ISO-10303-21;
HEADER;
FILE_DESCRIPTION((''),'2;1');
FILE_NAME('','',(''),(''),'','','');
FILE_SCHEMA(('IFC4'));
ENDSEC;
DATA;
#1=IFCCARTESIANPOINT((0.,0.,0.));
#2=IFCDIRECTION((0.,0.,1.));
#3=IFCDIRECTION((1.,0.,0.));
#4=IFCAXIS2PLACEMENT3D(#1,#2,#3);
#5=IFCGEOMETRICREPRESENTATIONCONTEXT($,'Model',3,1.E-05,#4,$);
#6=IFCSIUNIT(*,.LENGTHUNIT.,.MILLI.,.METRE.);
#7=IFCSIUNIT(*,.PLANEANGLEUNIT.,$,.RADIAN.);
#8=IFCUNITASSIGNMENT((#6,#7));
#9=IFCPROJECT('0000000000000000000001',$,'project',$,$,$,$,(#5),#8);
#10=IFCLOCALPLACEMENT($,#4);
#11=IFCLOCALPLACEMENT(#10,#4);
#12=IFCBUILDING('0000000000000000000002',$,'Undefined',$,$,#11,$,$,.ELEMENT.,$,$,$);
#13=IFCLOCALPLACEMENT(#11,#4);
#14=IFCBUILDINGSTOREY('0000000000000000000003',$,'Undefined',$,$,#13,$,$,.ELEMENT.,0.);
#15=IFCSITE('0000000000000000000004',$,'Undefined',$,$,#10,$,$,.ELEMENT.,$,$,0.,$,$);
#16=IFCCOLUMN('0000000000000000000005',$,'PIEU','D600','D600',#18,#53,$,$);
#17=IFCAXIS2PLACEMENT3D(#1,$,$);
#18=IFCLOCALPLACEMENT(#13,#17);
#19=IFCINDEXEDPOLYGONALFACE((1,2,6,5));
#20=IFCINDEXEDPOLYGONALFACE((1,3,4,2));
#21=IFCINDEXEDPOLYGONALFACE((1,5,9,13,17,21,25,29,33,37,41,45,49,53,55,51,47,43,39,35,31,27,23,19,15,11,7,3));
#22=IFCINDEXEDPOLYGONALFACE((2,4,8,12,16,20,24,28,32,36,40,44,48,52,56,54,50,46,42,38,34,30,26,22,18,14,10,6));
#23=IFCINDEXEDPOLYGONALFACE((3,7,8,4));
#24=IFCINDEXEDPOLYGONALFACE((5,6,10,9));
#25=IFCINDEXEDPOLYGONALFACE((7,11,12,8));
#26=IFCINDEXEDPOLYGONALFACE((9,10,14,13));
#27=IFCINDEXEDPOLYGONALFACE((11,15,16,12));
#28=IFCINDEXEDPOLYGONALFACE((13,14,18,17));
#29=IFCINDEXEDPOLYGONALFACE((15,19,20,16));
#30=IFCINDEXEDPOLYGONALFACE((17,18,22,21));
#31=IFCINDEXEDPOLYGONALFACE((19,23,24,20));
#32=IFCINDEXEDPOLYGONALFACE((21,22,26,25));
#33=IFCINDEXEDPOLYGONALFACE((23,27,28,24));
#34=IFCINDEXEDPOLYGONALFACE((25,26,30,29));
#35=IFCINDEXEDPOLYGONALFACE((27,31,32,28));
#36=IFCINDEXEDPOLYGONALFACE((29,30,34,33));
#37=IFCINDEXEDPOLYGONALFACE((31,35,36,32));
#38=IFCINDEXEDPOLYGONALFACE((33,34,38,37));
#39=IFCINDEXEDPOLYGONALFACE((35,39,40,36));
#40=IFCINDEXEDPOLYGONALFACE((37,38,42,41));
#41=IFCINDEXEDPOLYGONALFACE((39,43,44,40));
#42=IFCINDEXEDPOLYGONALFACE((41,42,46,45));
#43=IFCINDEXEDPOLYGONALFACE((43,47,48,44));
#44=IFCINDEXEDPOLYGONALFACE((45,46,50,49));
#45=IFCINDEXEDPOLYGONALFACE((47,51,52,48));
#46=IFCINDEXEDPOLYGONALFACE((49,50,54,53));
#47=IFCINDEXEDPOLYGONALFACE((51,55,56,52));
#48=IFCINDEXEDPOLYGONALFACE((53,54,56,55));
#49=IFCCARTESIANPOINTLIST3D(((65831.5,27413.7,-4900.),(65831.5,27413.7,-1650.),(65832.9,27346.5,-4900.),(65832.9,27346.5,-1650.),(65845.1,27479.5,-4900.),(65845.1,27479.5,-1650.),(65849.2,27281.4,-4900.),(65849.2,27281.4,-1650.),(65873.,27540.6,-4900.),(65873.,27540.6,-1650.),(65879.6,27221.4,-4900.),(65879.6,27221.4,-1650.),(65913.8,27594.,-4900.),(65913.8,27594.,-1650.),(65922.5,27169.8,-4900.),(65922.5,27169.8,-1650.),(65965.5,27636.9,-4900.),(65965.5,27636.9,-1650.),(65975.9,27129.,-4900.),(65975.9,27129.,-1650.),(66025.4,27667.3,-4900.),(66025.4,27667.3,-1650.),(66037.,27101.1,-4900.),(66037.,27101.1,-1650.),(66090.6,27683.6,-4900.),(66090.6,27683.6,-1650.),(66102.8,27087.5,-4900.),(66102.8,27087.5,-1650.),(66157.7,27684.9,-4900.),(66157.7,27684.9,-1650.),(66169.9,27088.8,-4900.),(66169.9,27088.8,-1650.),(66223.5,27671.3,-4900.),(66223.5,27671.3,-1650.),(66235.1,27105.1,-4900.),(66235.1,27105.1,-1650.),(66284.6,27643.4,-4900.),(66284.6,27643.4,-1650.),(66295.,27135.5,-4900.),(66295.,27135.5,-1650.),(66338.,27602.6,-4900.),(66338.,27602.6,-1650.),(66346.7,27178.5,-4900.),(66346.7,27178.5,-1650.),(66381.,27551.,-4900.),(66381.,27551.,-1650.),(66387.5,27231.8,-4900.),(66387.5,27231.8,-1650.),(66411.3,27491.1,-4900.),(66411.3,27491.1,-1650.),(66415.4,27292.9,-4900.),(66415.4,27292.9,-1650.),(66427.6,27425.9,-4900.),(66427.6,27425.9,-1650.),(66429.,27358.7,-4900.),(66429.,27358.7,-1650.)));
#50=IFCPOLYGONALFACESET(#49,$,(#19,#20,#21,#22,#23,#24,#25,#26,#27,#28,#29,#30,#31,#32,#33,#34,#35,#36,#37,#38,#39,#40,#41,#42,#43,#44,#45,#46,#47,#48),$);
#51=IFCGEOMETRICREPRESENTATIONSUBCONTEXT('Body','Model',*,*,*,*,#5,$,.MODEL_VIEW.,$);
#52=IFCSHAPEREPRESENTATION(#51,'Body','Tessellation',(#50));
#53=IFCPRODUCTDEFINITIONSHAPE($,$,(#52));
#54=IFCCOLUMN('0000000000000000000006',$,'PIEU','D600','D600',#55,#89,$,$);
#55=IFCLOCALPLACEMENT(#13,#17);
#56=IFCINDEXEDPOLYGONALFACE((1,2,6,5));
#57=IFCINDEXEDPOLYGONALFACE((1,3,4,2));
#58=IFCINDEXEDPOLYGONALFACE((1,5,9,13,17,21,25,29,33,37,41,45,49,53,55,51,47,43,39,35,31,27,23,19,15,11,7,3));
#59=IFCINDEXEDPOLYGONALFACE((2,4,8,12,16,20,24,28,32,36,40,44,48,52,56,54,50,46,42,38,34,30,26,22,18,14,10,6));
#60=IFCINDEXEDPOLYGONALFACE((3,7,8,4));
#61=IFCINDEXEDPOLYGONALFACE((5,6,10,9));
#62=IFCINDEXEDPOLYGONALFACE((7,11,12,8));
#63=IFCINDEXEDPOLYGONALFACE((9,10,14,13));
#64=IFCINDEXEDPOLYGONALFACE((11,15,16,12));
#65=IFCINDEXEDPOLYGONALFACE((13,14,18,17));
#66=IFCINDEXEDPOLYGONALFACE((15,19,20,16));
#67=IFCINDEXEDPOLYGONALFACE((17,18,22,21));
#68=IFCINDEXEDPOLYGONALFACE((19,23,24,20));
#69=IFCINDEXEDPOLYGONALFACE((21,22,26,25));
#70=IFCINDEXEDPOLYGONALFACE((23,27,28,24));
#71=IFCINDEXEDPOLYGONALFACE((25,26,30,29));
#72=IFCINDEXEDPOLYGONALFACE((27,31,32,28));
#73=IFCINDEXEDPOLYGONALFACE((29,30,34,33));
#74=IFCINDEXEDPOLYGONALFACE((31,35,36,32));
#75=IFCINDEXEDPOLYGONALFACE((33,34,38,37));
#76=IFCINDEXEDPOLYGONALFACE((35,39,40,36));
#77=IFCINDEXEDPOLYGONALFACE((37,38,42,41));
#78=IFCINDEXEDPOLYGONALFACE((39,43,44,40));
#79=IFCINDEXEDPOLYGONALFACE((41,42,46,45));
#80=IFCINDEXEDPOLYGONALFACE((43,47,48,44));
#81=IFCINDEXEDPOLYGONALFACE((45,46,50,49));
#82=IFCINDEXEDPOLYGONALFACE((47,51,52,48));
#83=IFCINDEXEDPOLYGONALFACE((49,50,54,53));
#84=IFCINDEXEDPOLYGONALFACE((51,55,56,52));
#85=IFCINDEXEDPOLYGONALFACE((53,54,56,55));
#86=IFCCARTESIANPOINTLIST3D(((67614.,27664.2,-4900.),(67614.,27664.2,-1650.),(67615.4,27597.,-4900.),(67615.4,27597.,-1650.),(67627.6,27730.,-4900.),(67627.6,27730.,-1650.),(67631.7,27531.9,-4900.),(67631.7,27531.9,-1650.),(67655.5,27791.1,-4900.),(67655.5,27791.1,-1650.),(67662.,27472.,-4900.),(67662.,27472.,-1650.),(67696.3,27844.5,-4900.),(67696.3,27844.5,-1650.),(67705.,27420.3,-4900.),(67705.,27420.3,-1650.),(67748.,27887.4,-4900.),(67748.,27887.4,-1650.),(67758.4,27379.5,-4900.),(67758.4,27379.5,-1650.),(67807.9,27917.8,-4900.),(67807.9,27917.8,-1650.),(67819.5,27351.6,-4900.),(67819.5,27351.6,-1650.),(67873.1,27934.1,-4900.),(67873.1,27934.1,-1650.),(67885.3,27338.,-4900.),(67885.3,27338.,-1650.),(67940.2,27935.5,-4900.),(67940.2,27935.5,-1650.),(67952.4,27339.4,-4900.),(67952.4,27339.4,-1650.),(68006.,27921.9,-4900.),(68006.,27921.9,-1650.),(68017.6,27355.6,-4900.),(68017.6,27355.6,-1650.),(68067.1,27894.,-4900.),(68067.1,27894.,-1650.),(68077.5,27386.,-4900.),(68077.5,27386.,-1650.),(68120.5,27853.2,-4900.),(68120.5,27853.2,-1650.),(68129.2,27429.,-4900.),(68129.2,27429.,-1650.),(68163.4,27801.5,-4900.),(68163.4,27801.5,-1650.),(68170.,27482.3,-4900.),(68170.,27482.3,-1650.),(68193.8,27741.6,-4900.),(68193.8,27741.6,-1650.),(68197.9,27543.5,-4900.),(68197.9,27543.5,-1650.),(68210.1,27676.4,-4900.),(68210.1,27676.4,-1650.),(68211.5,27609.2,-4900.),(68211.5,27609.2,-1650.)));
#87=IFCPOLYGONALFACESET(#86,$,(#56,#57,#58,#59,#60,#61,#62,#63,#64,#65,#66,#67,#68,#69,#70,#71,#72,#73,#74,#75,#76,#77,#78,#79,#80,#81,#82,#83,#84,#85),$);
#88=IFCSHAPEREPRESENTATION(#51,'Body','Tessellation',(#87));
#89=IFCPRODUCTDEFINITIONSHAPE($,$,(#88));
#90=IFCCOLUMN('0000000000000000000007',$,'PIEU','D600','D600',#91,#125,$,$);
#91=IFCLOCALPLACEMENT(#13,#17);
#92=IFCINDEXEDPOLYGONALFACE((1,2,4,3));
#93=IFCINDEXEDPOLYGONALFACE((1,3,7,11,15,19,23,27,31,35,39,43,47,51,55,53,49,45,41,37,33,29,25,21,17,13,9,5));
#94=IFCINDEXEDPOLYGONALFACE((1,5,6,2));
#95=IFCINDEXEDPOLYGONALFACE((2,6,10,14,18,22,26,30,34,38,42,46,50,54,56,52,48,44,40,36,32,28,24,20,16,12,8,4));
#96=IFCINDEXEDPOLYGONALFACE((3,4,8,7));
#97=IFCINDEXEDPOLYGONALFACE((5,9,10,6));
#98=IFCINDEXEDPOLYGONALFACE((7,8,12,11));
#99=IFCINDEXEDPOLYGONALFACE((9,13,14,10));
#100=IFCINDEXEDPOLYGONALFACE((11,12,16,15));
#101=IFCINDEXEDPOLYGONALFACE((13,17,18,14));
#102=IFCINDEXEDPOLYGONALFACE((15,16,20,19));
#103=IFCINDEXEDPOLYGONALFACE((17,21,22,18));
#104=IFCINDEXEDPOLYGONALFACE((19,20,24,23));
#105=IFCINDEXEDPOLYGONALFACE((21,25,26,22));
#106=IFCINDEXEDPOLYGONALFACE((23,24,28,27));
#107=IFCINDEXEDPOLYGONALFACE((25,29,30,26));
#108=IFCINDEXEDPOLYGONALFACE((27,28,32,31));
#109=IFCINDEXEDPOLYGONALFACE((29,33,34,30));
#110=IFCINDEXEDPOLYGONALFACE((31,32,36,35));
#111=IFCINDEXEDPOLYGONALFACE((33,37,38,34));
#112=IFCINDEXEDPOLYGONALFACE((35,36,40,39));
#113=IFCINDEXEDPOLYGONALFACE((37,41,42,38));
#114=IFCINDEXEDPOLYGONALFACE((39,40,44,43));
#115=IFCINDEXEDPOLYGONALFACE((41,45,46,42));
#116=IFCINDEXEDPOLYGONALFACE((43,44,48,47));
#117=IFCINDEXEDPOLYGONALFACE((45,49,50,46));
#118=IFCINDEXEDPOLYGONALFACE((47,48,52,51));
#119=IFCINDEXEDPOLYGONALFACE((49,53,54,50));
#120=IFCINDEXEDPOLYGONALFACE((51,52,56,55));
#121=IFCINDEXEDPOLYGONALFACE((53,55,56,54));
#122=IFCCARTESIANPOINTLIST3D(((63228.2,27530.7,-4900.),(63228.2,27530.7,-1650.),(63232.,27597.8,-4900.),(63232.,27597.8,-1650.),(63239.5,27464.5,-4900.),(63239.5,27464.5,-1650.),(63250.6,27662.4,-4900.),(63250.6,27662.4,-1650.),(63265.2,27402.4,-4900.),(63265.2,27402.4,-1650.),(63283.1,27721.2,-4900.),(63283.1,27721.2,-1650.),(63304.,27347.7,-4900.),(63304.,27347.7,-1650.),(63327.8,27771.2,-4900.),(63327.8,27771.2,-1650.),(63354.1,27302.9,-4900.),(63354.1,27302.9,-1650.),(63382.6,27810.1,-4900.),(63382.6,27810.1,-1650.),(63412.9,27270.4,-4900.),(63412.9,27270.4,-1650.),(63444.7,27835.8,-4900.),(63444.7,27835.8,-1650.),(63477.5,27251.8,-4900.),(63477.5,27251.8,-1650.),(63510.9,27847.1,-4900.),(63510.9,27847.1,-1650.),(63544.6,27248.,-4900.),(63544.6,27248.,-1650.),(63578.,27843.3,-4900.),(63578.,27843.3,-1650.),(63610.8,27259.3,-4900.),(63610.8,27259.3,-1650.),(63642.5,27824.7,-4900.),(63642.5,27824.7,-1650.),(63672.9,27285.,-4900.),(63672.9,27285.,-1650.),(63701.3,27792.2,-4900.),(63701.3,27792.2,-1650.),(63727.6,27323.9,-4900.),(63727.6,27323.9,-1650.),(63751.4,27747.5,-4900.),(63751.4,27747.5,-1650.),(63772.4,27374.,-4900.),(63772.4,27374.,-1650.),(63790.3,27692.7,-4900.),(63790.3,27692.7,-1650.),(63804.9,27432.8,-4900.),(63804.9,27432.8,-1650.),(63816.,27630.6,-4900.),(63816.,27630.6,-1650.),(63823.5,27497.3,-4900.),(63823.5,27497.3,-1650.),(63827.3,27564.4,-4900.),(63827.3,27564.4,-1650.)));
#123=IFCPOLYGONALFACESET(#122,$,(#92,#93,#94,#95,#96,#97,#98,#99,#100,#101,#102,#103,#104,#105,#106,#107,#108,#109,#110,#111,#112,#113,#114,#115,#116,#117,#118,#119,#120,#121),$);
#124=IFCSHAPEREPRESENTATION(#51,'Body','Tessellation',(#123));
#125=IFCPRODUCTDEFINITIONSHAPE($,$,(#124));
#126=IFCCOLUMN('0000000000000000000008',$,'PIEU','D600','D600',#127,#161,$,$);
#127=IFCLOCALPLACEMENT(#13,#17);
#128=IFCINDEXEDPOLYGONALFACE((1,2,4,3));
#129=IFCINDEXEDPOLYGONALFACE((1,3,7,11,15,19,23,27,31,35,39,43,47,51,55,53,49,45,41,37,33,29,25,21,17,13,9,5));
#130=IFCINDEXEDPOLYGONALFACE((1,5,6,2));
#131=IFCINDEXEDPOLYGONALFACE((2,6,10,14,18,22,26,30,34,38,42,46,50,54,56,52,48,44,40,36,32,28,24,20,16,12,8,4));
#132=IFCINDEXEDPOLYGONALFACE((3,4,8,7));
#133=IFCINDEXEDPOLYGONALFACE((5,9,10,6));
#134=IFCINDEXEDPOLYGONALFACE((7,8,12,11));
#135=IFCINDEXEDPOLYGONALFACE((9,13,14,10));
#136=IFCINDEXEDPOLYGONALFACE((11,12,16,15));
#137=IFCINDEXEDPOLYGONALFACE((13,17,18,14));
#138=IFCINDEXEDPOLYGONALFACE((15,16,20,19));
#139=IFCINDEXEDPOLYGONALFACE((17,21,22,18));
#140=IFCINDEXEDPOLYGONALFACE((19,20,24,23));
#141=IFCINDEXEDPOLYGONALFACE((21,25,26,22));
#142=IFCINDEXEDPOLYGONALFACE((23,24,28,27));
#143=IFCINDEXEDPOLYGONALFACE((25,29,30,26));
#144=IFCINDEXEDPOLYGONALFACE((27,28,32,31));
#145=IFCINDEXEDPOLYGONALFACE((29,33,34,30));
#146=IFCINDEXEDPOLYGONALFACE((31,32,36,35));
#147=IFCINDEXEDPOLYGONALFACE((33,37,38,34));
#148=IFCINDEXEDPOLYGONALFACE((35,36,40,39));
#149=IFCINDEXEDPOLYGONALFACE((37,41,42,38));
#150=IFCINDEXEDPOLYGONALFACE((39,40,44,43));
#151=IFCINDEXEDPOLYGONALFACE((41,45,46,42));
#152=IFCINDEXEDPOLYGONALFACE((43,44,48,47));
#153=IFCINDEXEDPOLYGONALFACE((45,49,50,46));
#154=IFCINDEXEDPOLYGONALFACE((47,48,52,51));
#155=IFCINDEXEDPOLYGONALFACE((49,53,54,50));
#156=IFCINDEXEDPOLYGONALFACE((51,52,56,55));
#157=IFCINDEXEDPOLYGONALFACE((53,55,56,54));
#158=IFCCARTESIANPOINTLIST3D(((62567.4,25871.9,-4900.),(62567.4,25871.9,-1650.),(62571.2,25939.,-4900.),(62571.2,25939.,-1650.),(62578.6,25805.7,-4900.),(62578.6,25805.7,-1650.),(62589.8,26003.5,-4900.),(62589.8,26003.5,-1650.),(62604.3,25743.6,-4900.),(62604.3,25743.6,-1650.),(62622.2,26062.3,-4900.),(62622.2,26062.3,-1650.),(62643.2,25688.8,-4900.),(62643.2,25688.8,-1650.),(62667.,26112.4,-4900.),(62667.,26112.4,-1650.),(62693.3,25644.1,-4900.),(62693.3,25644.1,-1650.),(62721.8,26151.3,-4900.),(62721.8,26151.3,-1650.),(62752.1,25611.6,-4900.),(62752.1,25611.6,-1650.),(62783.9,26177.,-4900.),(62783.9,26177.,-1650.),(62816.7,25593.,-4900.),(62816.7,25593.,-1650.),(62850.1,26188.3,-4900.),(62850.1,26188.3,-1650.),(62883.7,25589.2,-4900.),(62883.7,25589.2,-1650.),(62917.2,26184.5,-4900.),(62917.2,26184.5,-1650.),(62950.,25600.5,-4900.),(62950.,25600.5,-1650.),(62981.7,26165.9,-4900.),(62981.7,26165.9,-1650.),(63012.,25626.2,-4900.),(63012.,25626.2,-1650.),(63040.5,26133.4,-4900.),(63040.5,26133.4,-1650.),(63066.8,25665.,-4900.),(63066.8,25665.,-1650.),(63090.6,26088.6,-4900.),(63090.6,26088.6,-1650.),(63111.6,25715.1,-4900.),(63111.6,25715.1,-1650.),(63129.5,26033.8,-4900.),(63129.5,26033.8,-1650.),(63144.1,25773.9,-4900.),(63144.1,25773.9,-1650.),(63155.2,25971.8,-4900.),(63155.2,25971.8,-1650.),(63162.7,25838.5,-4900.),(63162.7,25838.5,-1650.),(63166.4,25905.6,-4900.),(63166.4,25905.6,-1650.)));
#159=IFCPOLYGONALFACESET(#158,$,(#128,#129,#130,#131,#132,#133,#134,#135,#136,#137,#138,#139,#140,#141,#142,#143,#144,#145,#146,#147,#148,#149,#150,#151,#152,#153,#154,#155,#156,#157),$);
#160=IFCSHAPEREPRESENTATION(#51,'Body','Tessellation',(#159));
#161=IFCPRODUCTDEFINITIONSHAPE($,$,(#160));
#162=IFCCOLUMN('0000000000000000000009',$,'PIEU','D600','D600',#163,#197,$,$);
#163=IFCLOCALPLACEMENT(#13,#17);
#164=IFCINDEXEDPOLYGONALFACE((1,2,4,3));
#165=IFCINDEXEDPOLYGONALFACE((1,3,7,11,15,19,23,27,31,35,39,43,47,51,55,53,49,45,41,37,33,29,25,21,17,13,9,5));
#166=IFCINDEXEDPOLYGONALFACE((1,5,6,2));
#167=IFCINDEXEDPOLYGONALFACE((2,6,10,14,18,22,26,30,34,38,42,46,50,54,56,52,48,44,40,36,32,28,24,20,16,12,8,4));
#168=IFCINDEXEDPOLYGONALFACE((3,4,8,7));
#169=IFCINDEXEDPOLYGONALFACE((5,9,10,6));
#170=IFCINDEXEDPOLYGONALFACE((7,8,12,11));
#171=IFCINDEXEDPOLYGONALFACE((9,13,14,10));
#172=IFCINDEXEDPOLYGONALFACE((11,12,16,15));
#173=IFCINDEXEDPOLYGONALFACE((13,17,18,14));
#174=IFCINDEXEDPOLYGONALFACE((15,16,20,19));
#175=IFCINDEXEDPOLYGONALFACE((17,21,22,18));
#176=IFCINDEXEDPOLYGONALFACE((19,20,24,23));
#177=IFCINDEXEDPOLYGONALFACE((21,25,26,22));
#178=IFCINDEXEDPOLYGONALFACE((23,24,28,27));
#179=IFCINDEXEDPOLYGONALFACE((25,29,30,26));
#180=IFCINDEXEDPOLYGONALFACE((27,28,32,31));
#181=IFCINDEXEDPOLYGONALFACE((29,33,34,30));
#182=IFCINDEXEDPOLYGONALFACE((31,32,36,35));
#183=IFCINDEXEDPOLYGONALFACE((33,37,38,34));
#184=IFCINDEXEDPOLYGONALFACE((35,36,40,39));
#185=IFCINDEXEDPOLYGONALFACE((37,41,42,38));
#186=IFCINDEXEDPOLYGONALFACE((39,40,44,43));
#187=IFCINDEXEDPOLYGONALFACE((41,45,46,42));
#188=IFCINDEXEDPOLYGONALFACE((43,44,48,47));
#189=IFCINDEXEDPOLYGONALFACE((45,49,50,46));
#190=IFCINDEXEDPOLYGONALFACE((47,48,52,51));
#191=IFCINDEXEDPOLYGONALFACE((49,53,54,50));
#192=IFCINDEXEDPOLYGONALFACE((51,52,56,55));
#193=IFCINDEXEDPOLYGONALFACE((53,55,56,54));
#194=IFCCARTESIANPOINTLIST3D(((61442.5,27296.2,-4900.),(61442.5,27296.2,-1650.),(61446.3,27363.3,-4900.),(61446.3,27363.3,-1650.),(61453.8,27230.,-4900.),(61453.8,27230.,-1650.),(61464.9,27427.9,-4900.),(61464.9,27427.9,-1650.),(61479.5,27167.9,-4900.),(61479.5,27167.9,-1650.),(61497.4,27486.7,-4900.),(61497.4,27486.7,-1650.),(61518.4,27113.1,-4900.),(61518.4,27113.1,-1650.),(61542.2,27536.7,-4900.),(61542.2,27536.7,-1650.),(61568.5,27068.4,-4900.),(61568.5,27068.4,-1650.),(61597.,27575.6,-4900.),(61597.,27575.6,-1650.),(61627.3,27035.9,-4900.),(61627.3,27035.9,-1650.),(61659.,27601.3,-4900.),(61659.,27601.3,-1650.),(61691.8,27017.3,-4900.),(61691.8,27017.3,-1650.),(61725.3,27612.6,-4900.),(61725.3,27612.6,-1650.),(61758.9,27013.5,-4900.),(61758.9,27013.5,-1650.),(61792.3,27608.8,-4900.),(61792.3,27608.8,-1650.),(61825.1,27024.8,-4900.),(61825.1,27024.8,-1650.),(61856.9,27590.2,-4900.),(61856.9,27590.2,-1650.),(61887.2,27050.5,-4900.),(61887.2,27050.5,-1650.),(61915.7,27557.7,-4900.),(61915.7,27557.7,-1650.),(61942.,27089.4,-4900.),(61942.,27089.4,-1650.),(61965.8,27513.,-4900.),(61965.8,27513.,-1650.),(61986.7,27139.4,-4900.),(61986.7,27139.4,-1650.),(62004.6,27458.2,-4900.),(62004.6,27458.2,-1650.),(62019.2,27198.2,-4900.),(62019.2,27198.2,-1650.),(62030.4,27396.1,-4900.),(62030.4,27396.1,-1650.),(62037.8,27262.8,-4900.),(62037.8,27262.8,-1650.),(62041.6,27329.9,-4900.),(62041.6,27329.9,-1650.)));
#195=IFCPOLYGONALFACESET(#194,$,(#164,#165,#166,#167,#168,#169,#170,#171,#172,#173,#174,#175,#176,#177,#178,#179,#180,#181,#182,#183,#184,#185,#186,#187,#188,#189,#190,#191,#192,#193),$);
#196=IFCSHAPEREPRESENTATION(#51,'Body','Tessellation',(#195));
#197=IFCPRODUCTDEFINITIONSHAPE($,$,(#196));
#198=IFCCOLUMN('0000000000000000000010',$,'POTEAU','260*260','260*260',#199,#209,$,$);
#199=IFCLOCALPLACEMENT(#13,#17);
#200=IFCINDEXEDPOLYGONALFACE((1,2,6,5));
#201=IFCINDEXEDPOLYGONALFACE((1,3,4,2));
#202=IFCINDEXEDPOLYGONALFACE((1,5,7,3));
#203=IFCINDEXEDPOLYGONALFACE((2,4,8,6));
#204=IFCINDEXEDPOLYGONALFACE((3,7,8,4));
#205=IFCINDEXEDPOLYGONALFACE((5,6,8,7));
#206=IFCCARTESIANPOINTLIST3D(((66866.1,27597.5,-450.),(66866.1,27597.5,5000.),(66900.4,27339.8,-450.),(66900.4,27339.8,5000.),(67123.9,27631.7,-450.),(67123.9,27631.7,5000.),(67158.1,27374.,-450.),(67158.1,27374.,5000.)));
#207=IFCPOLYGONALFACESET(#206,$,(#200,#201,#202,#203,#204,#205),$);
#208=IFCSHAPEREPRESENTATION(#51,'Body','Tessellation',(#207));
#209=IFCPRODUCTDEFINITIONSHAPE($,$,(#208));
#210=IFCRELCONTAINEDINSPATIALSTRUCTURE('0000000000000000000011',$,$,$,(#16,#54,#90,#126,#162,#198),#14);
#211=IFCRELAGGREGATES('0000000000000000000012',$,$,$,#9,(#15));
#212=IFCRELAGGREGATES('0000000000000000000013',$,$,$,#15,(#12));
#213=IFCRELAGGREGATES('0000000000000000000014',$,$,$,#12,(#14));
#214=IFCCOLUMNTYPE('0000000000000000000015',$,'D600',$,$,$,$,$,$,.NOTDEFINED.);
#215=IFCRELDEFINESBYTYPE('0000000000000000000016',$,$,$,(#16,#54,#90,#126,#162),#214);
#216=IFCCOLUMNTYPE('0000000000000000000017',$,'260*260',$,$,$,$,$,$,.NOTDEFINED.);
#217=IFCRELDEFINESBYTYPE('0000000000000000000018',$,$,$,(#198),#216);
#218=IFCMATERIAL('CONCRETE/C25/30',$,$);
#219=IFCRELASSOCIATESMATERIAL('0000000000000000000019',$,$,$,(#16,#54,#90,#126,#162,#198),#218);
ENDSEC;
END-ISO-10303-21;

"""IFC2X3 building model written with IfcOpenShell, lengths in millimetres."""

from ifc_helpers import new_model, si_unit, frame, origin_with_axes, origin_2d_with_axis, place, context, subcontext, project, spatial, rectangle, circle, extrude, material, type_object, element, save


model = new_model("IFC2X3")

# Units and contexts
model_context = context("Model", 3, precision=1e-05, world=origin_with_axes())
body_context = subcontext(model_context, "Body", "Model", "MODEL_VIEW")
ifc_project = project(units=[si_unit("LENGTHUNIT", "METRE", prefix="MILLI"), si_unit("PLANEANGLEUNIT", "RADIAN")], contexts=[model_context])

# Site, building, storey
site_placement = place(None, origin_with_axes())
site = spatial("IfcSite", under=ifc_project, at=site_placement, Name="Undefined", CompositionType="ELEMENT", RefElevation=0.0)
building_placement = place(site_placement, origin_with_axes())
building = spatial("IfcBuilding", under=site, at=building_placement, Name="Undefined", CompositionType="ELEMENT")
storey_placement = place(building_placement, origin_with_axes())
storey = spatial("IfcBuildingStorey", under=building, at=storey_placement, Name="Undefined", CompositionType="ELEMENT", Elevation=0.0)

# Columns
ifc_material_1 = material(Name="CONCRETE/C25/30")
column_type_1 = type_object("IfcColumnType", Name="D600", PredefinedType="NOTDEFINED")
for number, where, z_axis, x_axis, name in (
    (1, (66130.3, 27386.2, -4900.0), (0.0, 0.0, 1.0), (1.0, 0.0, 0.0), "PIEU"),
    (2, (67912.7, 27636.7, -4900.0), (0.0, 0.0, 1.0), (1.0, 0.0, 0.0), "PIEU"),
):
    element("IfcColumn", number, at=place(storey_placement, frame(where, z_axis=z_axis, x_axis=x_axis)), inside=storey, type_object=column_type_1, material=ifc_material_1, Name=name, Description="D600", ObjectType="D600", context=body_context, shape_type="SweptSolid", body=[
        extrude(circle(Radius=300.0, at=origin_2d_with_axis()), frame((0.0, 0.0, 3250.0), z_axis=(0.0, 0.0, -1.0), x_axis=(-0.132256, 0.991216, 0.0)), (0.0, 0.0, 1.0), 3250.0),
    ])
for number, where, z_axis, x_axis, name in (
    (3, (63527.7, 27547.6, -4900.0), (0.0, 0.0, 1.0), (1.0, 0.0, 0.0), "PIEU"),
    (4, (62866.9, 25888.7, -4900.0), (0.0, 0.0, 1.0), (1.0, 0.0, 0.0), "PIEU"),
    (5, (61742.1, 27313.1, -4900.0), (0.0, 0.0, 1.0), (1.0, 0.0, 0.0), "PIEU"),
):
    element("IfcColumn", number, at=place(storey_placement, frame(where, z_axis=z_axis, x_axis=x_axis)), inside=storey, type_object=column_type_1, material=ifc_material_1, Name=name, Description="D600", ObjectType="D600", context=body_context, shape_type="SweptSolid", body=[
        extrude(circle(Radius=300.0, at=origin_2d_with_axis()), frame((0.0, 0.0, 3250.0), z_axis=(0.0, 0.0, -1.0), x_axis=(-0.382683, -0.92388, 0.0)), (0.0, 0.0, 1.0), 3250.0),
    ])
column_type_2 = type_object("IfcColumnType", Name="260*260", PredefinedType="NOTDEFINED")
column_1_placement = place(storey_placement, frame((67012.1, 27485.7, -450.0), z_axis=(0.0, 0.0, 1.0), x_axis=(1.0, 0.0, 0.0)))
element("IfcColumn", 6, at=column_1_placement, inside=storey, type_object=column_type_2, material=ifc_material_1, Name="POTEAU", Description="260*260", ObjectType="260*260", context=body_context, shape_type="SweptSolid", body=[
    extrude(rectangle(XDim=260.0, YDim=260.0, at=origin_2d_with_axis()), frame((0.0, 0.0, 5450.0), z_axis=(0.0, 0.0, -1.0), x_axis=(-0.131727, 0.991286, 0.0)), (0.0, 0.0, 1.0), 5450.0),
])

save(model, "model.ifc")
